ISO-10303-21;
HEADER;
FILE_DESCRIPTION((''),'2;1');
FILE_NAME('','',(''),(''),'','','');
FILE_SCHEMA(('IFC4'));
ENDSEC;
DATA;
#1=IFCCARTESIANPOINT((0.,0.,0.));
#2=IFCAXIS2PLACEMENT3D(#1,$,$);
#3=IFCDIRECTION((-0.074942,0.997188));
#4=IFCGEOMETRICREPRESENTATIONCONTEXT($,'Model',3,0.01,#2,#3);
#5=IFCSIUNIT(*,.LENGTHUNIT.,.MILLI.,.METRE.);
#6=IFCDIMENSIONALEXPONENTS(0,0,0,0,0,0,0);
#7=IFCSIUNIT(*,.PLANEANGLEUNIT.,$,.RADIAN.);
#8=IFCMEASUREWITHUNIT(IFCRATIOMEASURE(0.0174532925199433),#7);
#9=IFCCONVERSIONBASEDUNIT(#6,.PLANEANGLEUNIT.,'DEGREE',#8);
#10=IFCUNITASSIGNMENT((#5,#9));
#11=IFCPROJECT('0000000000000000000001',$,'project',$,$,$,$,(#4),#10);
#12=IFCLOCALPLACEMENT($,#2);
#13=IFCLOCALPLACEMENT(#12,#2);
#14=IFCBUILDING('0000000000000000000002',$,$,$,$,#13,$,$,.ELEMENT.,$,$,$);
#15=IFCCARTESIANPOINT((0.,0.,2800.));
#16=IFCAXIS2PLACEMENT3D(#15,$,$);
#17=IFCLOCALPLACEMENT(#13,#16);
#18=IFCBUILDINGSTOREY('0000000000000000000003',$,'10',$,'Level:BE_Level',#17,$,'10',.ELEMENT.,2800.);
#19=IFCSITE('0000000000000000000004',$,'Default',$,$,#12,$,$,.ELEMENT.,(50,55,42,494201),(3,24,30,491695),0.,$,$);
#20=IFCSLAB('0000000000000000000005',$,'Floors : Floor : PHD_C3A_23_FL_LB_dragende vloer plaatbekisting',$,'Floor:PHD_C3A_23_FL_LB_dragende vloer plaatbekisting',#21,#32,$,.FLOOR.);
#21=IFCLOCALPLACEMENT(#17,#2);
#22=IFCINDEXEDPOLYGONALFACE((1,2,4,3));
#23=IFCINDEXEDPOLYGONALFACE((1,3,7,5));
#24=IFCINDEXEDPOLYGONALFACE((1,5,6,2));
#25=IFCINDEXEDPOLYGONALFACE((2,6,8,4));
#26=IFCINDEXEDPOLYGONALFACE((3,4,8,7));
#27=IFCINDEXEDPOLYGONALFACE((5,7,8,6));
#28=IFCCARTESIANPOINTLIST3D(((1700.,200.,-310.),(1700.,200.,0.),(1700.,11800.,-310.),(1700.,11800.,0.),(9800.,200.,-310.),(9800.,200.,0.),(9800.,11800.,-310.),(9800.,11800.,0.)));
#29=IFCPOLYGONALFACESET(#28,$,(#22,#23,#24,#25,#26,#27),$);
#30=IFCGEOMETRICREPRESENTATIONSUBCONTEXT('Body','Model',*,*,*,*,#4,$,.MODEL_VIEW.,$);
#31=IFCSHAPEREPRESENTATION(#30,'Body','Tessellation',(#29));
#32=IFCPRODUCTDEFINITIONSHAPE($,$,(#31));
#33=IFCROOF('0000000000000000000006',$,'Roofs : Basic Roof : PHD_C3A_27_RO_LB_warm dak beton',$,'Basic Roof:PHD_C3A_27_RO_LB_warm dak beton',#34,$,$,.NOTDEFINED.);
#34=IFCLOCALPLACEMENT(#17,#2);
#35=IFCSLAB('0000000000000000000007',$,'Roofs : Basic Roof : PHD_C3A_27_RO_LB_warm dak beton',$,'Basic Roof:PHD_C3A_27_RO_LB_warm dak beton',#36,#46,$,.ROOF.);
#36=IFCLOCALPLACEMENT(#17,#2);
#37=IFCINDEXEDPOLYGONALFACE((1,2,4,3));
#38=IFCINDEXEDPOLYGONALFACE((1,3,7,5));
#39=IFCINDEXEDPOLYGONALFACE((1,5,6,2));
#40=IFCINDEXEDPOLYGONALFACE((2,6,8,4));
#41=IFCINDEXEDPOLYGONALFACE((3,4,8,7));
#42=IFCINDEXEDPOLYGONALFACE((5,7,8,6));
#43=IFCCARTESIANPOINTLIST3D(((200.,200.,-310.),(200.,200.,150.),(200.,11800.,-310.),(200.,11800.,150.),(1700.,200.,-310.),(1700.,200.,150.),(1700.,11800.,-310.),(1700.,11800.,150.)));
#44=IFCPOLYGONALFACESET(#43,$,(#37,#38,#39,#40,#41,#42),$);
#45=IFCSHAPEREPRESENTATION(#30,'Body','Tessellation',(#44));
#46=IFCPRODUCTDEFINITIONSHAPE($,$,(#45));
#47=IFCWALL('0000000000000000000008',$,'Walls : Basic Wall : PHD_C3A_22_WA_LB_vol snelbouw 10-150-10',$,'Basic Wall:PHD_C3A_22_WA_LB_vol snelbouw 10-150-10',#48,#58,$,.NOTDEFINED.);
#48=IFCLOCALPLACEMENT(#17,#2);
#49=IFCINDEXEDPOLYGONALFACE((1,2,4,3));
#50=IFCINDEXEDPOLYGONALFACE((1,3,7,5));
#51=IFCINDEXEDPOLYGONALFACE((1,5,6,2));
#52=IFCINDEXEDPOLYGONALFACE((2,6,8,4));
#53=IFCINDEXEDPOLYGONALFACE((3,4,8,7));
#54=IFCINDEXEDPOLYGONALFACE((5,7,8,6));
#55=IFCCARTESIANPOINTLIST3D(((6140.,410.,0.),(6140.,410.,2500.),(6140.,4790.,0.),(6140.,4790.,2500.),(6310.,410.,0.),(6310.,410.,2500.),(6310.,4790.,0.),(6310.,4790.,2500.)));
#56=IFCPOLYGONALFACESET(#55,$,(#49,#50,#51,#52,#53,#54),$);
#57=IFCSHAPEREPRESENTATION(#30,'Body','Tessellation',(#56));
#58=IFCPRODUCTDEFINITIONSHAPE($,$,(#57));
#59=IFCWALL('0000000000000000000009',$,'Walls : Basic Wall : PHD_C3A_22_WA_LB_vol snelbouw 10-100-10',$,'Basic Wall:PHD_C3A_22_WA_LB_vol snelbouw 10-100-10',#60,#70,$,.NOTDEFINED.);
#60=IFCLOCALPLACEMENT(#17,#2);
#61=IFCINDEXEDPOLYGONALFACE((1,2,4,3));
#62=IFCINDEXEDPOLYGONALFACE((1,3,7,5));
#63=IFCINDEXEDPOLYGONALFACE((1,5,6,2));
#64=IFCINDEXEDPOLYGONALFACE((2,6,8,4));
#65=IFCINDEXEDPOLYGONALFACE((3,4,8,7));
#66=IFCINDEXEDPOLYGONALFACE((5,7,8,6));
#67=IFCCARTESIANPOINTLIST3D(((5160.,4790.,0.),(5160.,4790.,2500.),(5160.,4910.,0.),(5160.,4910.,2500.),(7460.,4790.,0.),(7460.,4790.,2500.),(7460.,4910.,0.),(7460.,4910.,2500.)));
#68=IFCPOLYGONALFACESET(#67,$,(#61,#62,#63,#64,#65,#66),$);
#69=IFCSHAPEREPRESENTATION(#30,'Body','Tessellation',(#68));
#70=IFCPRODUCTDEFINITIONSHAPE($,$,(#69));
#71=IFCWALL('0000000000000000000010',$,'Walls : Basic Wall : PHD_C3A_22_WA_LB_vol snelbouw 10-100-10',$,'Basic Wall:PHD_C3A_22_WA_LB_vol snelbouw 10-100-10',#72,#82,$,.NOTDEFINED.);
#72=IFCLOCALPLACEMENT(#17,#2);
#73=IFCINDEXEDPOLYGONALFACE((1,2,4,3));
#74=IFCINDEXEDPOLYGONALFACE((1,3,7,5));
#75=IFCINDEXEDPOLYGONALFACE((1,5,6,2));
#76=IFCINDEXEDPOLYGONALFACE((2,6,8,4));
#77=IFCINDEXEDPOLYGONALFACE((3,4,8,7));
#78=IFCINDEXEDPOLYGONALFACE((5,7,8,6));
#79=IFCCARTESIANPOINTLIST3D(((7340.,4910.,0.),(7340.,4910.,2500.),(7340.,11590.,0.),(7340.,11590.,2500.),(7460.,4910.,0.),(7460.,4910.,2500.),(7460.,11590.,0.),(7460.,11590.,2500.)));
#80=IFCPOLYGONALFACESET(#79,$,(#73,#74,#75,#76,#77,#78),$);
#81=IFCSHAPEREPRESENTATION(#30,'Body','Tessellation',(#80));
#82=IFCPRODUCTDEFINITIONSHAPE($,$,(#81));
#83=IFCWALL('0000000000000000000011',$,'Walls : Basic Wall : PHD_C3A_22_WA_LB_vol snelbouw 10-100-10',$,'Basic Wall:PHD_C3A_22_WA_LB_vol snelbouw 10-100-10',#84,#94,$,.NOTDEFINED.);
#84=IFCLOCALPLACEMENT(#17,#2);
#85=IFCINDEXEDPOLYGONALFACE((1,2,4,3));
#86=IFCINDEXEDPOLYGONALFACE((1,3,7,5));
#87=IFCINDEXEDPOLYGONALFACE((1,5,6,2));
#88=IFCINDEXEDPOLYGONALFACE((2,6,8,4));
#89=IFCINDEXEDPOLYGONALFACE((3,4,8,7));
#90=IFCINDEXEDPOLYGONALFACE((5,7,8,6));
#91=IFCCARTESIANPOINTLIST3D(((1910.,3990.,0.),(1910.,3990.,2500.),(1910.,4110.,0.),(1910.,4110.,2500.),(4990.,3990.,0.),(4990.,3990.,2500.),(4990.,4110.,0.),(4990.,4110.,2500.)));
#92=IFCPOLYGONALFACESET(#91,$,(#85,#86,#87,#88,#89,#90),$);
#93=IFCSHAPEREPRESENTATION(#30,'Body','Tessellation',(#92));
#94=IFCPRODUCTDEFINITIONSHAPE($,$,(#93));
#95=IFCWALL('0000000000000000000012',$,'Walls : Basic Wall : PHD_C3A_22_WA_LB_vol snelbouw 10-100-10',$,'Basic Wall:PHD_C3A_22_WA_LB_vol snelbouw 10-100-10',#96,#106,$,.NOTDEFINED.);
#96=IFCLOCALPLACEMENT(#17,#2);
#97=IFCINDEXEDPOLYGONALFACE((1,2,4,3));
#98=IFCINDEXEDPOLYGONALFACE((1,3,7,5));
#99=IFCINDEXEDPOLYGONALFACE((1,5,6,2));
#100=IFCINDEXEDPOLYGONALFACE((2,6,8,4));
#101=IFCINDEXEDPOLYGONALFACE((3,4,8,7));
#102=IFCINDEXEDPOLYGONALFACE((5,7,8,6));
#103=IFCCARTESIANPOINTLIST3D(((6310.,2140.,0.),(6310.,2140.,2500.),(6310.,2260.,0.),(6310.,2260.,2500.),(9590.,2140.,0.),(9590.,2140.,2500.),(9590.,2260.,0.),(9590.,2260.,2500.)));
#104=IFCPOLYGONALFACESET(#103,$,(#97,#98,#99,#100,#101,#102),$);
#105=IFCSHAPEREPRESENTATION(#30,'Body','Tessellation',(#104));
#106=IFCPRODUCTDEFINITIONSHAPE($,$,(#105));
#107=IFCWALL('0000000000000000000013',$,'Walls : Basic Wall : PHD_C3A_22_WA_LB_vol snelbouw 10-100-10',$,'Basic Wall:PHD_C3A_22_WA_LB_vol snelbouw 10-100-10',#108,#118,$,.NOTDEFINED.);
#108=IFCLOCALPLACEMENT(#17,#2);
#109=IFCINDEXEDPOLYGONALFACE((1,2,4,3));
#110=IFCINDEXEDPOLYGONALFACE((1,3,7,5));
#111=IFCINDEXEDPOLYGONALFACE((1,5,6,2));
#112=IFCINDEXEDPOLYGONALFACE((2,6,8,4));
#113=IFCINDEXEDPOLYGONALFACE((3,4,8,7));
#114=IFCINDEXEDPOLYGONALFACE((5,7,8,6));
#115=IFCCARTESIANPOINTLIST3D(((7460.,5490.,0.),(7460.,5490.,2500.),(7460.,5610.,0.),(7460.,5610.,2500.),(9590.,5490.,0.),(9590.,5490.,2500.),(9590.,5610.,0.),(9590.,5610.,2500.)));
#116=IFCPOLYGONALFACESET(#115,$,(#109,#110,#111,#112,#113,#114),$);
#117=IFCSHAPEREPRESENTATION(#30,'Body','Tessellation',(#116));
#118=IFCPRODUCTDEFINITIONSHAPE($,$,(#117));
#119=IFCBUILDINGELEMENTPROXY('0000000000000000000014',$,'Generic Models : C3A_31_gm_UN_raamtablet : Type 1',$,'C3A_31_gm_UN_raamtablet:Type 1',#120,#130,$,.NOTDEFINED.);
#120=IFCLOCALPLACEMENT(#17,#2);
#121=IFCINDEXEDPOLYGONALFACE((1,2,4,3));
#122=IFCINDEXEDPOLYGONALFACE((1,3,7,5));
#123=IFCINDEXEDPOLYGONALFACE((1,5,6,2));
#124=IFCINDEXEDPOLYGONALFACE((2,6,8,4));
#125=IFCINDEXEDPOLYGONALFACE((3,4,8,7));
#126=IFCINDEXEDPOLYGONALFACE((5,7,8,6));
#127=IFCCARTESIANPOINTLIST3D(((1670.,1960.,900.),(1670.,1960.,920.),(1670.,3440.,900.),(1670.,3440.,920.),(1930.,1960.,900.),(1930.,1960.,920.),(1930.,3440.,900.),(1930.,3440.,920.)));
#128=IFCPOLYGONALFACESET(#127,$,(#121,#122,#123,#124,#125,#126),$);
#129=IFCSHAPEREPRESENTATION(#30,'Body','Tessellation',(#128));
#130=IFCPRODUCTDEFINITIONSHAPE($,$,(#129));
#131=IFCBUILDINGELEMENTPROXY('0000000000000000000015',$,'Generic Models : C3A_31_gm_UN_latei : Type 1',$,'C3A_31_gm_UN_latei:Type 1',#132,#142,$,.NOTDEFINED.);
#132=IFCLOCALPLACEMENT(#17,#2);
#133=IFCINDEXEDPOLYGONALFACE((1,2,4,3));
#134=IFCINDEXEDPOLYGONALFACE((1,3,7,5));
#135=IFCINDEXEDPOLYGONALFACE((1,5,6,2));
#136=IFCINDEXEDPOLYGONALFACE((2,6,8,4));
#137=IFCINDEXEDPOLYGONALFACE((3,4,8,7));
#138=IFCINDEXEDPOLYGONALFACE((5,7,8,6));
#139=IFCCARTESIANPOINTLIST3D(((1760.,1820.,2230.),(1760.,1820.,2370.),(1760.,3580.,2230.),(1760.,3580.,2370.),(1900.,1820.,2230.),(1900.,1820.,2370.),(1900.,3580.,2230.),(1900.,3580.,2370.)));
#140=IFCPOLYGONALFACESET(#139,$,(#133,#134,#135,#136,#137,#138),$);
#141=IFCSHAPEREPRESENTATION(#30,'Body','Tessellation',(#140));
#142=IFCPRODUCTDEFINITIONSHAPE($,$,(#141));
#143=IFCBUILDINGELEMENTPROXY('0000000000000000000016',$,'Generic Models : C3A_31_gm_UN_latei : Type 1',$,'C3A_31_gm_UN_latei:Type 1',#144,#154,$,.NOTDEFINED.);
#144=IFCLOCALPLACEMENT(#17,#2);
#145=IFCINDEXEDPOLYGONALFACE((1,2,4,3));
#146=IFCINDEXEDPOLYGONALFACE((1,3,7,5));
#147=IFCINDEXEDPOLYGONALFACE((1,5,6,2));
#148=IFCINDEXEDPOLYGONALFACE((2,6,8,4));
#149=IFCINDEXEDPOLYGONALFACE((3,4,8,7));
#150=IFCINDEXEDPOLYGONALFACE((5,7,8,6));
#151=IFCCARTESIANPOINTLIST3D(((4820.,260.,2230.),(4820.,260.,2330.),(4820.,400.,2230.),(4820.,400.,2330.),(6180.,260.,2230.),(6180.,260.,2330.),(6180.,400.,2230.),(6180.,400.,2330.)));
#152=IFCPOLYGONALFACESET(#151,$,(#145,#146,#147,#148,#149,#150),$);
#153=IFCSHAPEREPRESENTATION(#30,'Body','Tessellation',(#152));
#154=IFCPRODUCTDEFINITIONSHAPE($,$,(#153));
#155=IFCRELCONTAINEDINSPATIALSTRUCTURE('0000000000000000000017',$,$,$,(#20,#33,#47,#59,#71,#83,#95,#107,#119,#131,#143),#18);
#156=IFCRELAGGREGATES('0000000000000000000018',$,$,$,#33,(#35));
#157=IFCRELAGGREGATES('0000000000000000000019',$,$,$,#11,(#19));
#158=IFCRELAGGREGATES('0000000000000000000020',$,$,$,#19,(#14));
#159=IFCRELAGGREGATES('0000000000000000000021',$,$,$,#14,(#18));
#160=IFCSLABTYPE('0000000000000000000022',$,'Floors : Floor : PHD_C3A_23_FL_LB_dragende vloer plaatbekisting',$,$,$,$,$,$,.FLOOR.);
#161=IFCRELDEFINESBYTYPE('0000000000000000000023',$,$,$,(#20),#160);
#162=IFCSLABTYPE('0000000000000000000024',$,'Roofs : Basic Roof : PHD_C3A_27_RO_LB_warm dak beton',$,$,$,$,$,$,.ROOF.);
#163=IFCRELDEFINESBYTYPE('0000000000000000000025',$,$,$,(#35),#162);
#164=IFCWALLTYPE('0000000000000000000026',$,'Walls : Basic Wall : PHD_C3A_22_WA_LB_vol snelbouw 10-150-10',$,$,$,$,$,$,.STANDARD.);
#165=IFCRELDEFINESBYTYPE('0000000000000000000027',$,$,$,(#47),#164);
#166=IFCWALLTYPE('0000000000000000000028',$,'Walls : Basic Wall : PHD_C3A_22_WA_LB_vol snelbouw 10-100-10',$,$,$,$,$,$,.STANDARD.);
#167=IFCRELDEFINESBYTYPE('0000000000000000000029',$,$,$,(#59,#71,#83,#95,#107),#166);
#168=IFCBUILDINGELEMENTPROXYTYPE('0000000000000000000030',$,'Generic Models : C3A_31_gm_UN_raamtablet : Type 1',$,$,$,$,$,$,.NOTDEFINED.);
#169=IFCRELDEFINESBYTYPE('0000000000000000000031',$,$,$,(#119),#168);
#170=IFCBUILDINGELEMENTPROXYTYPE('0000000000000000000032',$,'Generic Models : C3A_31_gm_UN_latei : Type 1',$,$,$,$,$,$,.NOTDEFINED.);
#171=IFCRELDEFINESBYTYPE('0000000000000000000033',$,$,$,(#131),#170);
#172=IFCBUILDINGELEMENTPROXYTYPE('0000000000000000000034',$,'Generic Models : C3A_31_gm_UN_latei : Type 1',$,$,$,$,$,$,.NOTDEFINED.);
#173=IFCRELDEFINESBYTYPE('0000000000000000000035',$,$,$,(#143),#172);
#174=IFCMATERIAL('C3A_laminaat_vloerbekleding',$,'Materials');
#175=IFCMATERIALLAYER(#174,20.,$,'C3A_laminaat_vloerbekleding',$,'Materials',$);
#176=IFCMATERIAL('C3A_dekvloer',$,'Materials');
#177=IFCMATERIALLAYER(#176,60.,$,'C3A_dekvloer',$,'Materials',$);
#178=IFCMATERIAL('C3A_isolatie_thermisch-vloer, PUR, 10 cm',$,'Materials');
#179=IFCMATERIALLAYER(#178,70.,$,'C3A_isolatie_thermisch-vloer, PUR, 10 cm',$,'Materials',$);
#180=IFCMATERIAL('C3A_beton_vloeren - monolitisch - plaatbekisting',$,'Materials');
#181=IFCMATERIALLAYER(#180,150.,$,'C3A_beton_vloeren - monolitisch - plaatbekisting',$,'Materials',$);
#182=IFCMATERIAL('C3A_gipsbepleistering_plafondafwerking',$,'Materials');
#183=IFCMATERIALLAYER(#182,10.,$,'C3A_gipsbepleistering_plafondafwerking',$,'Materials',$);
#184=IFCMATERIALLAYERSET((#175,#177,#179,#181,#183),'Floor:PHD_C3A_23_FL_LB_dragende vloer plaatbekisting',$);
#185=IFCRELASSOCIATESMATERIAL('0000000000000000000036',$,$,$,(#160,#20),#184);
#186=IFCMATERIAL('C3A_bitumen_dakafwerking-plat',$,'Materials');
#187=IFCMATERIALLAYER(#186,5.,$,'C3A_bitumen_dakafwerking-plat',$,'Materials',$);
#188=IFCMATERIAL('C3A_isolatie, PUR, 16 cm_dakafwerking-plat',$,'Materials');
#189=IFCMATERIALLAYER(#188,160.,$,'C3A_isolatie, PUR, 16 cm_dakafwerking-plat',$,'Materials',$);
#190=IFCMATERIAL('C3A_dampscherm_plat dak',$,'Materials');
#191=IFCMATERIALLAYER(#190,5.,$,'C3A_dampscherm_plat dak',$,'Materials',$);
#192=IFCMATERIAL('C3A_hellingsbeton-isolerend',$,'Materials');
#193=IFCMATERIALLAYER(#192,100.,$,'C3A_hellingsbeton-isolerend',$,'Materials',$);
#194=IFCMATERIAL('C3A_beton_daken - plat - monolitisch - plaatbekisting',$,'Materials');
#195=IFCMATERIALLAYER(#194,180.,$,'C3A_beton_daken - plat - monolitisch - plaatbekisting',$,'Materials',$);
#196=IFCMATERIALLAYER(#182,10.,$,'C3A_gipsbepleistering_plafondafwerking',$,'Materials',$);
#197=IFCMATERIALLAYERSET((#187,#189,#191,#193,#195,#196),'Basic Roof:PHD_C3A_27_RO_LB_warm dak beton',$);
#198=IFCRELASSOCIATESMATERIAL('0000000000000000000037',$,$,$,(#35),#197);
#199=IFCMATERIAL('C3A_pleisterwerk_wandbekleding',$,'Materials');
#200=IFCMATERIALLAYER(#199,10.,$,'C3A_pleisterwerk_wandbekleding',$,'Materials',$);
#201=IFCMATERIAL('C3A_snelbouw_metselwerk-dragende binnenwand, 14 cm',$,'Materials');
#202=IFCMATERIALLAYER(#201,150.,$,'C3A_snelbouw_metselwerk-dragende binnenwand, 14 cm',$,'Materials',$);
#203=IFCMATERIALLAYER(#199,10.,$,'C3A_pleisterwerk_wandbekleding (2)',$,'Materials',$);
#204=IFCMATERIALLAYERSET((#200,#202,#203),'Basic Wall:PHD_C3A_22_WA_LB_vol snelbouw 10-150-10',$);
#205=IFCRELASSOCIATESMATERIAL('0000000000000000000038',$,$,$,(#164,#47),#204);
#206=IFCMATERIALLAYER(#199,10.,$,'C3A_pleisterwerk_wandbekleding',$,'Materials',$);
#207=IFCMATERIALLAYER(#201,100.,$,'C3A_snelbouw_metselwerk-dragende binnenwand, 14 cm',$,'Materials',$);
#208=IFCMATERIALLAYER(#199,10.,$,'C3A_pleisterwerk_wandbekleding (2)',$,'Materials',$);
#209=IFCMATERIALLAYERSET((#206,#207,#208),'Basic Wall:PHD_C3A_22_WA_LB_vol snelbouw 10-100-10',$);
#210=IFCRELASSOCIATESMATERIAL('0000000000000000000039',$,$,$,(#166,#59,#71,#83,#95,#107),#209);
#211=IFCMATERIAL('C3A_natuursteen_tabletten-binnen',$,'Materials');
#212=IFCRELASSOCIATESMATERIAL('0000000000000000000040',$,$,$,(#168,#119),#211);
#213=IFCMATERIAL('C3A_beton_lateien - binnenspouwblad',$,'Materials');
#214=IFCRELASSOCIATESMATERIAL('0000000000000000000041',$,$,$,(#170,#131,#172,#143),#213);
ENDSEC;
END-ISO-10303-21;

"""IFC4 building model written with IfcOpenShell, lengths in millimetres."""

from ifc_helpers import new_model, entity, si_unit, converted_unit, direction, frame, frame_2d, origin, origin_2d_with_axis, place, context, subcontext, project, spatial, rectangle, extrude, source, transform, mapped, material, layer, layer_set, layer_usage, type_object, type_shapes, element, aggregate, save


model = new_model("IFC4")

# Units and contexts
model_context = context("Model", 3, precision=0.01, world=origin(), true_north=direction((-0.074942, 0.997188)))
body_context = subcontext(model_context, "Body", "Model", "MODEL_VIEW")
ifc_project = project(units=[si_unit("LENGTHUNIT", "METRE", prefix="MILLI"), converted_unit("PLANEANGLEUNIT", "DEGREE", entity("IfcRatioMeasure", 0.0174532925199433), si_unit("PLANEANGLEUNIT", "RADIAN"), dimensions=[0, 0, 0, 0, 0, 0, 0])], contexts=[model_context])

# Site, building, storey
site_placement = place(None, origin())
site = spatial("IfcSite", under=ifc_project, at=site_placement, Name="Default", CompositionType="ELEMENT", RefLatitude=(50, 55, 42, 494201), RefLongitude=(3, 24, 30, 491695), RefElevation=0.0)
building_placement = place(site_placement, origin())
building = spatial("IfcBuilding", under=site, at=building_placement, CompositionType="ELEMENT")
storey_placement = place(building_placement, frame((0.0, 0.0, 2800.0)))
storey = spatial("IfcBuildingStorey", under=building, at=storey_placement, Name="10", ObjectType="Level:BE_Level", LongName="10", CompositionType="ELEMENT", Elevation=2800.0)

# Slab
ifc_material_1 = material(Name="C3A_laminaat_vloerbekleding", Category="Materials")
ifc_layer_1 = layer(ifc_material_1, 20.0, Name="C3A_laminaat_vloerbekleding", Category="Materials")
ifc_material_2 = material(Name="C3A_dekvloer", Category="Materials")
ifc_layer_2 = layer(ifc_material_2, 60.0, Name="C3A_dekvloer", Category="Materials")
ifc_material_3 = material(Name="C3A_isolatie_thermisch-vloer, PUR, 10 cm", Category="Materials")
ifc_layer_3 = layer(ifc_material_3, 70.0, Name="C3A_isolatie_thermisch-vloer, PUR, 10 cm", Category="Materials")
ifc_material_4 = material(Name="C3A_beton_vloeren - monolitisch - plaatbekisting", Category="Materials")
ifc_layer_4 = layer(ifc_material_4, 150.0, Name="C3A_beton_vloeren - monolitisch - plaatbekisting", Category="Materials")
ifc_material_5 = material(Name="C3A_gipsbepleistering_plafondafwerking", Category="Materials")
ifc_layer_5 = layer(ifc_material_5, 10.0, Name="C3A_gipsbepleistering_plafondafwerking", Category="Materials")
ifc_layer_set_1 = layer_set([ifc_layer_1, ifc_layer_2, ifc_layer_3, ifc_layer_4, ifc_layer_5], Name="Floor:PHD_C3A_23_FL_LB_dragende vloer plaatbekisting")
ifc_layer_usage_1 = layer_usage(ifc_layer_set_1, "AXIS3", "POSITIVE", 0.0)
slab_type_1 = type_object("IfcSlabType", Name="Floors : Floor : PHD_C3A_23_FL_LB_dragende vloer plaatbekisting", PredefinedType="FLOOR", material=ifc_layer_set_1)
slab_1_placement = place(storey_placement, origin())
element("IfcSlab", 1, at=slab_1_placement, inside=storey, type_object=slab_type_1, material=ifc_layer_usage_1, Name="Floors : Floor : PHD_C3A_23_FL_LB_dragende vloer plaatbekisting", ObjectType="Floor:PHD_C3A_23_FL_LB_dragende vloer plaatbekisting", PredefinedType="FLOOR", context=body_context, shape_type="SweptSolid", body=[
    extrude(rectangle(XDim=11600.0, YDim=8100.0, at=frame_2d((0.0, 0.0), x_axis=(1.0, 0.0))), frame((5750.0, 6000.0, 0.0), z_axis=(0.0, 0.0, -1.0), x_axis=(0.0, 1.0, 0.0)), (0.0, 0.0, 1.0), 310.0),
])

# Roof, slab
roof_placement = place(storey_placement, frame((200.0, 200.0, -310.0)))
roof = element("IfcRoof", 2, at=roof_placement, inside=storey, Name="Roofs : Basic Roof : PHD_C3A_27_RO_LB_warm dak beton", ObjectType="Basic Roof:PHD_C3A_27_RO_LB_warm dak beton", PredefinedType="NOTDEFINED")
ifc_material_6 = material(Name="C3A_bitumen_dakafwerking-plat", Category="Materials")
ifc_layer_6 = layer(ifc_material_6, 5.0, Name="C3A_bitumen_dakafwerking-plat", Category="Materials")
ifc_material_7 = material(Name="C3A_isolatie, PUR, 16 cm_dakafwerking-plat", Category="Materials")
ifc_layer_7 = layer(ifc_material_7, 160.0, Name="C3A_isolatie, PUR, 16 cm_dakafwerking-plat", Category="Materials")
ifc_material_8 = material(Name="C3A_dampscherm_plat dak", Category="Materials")
ifc_layer_8 = layer(ifc_material_8, 5.0, Name="C3A_dampscherm_plat dak", Category="Materials")
ifc_material_9 = material(Name="C3A_hellingsbeton-isolerend", Category="Materials")
ifc_layer_9 = layer(ifc_material_9, 100.0, Name="C3A_hellingsbeton-isolerend", Category="Materials")
ifc_material_10 = material(Name="C3A_beton_daken - plat - monolitisch - plaatbekisting", Category="Materials")
ifc_layer_10 = layer(ifc_material_10, 180.0, Name="C3A_beton_daken - plat - monolitisch - plaatbekisting", Category="Materials")
ifc_layer_11 = layer(ifc_material_5, 10.0, Name="C3A_gipsbepleistering_plafondafwerking", Category="Materials")
ifc_layer_set_2 = layer_set([ifc_layer_6, ifc_layer_7, ifc_layer_8, ifc_layer_9, ifc_layer_10, ifc_layer_11], Name="Basic Roof:PHD_C3A_27_RO_LB_warm dak beton")
slab_type_2 = type_object("IfcSlabType", Name="Roofs : Basic Roof : PHD_C3A_27_RO_LB_warm dak beton", PredefinedType="ROOF")
slab_2_placement = place(roof_placement, origin())
slab_2 = element("IfcSlab", 3, at=slab_2_placement, type_object=slab_type_2, material=ifc_layer_set_2, Name="Roofs : Basic Roof : PHD_C3A_27_RO_LB_warm dak beton", ObjectType="Basic Roof:PHD_C3A_27_RO_LB_warm dak beton", PredefinedType="ROOF", context=body_context, shape_type="SweptSolid", body=[
    extrude(rectangle(XDim=1500.0, YDim=11600.0, at=frame_2d((0.0, 0.0), x_axis=(1.0, 0.0))), frame((750.0, 5800.0, 0.0)), (0.0, 0.0, 1.0), 460.0),
])
aggregate(roof, [slab_2])

# Walls
ifc_material_11 = material(Name="C3A_pleisterwerk_wandbekleding", Category="Materials")
ifc_layer_12 = layer(ifc_material_11, 10.0, Name="C3A_pleisterwerk_wandbekleding", Category="Materials")
ifc_material_12 = material(Name="C3A_snelbouw_metselwerk-dragende binnenwand, 14 cm", Category="Materials")
ifc_layer_13 = layer(ifc_material_12, 150.0, Name="C3A_snelbouw_metselwerk-dragende binnenwand, 14 cm", Category="Materials")
ifc_layer_14 = layer(ifc_material_11, 10.0, Name="C3A_pleisterwerk_wandbekleding (2)", Category="Materials")
ifc_layer_set_3 = layer_set([ifc_layer_12, ifc_layer_13, ifc_layer_14], Name="Basic Wall:PHD_C3A_22_WA_LB_vol snelbouw 10-150-10")
ifc_layer_usage_2 = layer_usage(ifc_layer_set_3, "AXIS2", "NEGATIVE", 85.0)
wall_type_1 = type_object("IfcWallType", Name="Walls : Basic Wall : PHD_C3A_22_WA_LB_vol snelbouw 10-150-10", PredefinedType="STANDARD", material=ifc_layer_set_3)
wall_1_placement = place(storey_placement, frame((6225.0, 4790.0, 0.0), z_axis=(0.0, 0.0, 1.0), x_axis=(0.0, -1.0, 0.0)))
element("IfcWall", 4, at=wall_1_placement, inside=storey, type_object=wall_type_1, material=ifc_layer_usage_2, Name="Walls : Basic Wall : PHD_C3A_22_WA_LB_vol snelbouw 10-150-10", ObjectType="Basic Wall:PHD_C3A_22_WA_LB_vol snelbouw 10-150-10", PredefinedType="NOTDEFINED", context=body_context, shape_type="SweptSolid", body=[
    extrude(rectangle(XDim=4380.0, YDim=170.0, at=frame_2d((2190.0, 0.0), x_axis=(-1.0, 0.0))), origin(), (0.0, 0.0, 1.0), 2500.0),
])
ifc_layer_15 = layer(ifc_material_11, 10.0, Name="C3A_pleisterwerk_wandbekleding", Category="Materials")
ifc_layer_16 = layer(ifc_material_12, 100.0, Name="C3A_snelbouw_metselwerk-dragende binnenwand, 14 cm", Category="Materials")
ifc_layer_17 = layer(ifc_material_11, 10.0, Name="C3A_pleisterwerk_wandbekleding (2)", Category="Materials")
ifc_layer_set_4 = layer_set([ifc_layer_15, ifc_layer_16, ifc_layer_17], Name="Basic Wall:PHD_C3A_22_WA_LB_vol snelbouw 10-100-10")
ifc_layer_usage_3 = layer_usage(ifc_layer_set_4, "AXIS2", "NEGATIVE", 60.0)
wall_type_2 = type_object("IfcWallType", Name="Walls : Basic Wall : PHD_C3A_22_WA_LB_vol snelbouw 10-100-10", PredefinedType="STANDARD", material=ifc_layer_set_4)
wall_2_placement = place(storey_placement, frame((5160.0, 4850.0, 0.0)))
element("IfcWall", 5, at=wall_2_placement, inside=storey, type_object=wall_type_2, material=ifc_layer_usage_3, Name="Walls : Basic Wall : PHD_C3A_22_WA_LB_vol snelbouw 10-100-10", ObjectType="Basic Wall:PHD_C3A_22_WA_LB_vol snelbouw 10-100-10", PredefinedType="NOTDEFINED", context=body_context, shape_type="SweptSolid", body=[
    extrude(rectangle(XDim=2300.0, YDim=120.0, at=frame_2d((1150.0, 0.0), x_axis=(-1.0, 0.0))), origin(), (0.0, 0.0, 1.0), 2500.0),
])
ifc_layer_usage_4 = layer_usage(ifc_layer_set_4, "AXIS2", "NEGATIVE", 60.0)
wall_3_placement = place(storey_placement, frame((7400.0, 4910.0, 0.0), z_axis=(0.0, 0.0, 1.0), x_axis=(0.0, 1.0, 0.0)))
element("IfcWall", 6, at=wall_3_placement, inside=storey, type_object=wall_type_2, material=ifc_layer_usage_4, Name="Walls : Basic Wall : PHD_C3A_22_WA_LB_vol snelbouw 10-100-10", ObjectType="Basic Wall:PHD_C3A_22_WA_LB_vol snelbouw 10-100-10", PredefinedType="NOTDEFINED", context=body_context, shape_type="SweptSolid", body=[
    extrude(rectangle(XDim=6680.0, YDim=120.0, at=frame_2d((3340.0, 0.0), x_axis=(-1.0, 0.0))), origin(), (0.0, 0.0, 1.0), 2500.0),
])
ifc_layer_usage_5 = layer_usage(ifc_layer_set_4, "AXIS2", "NEGATIVE", 60.0)
wall_4_placement = place(storey_placement, frame((4990.0, 4050.0, 0.0), z_axis=(0.0, 0.0, 1.0), x_axis=(-1.0, 0.0, 0.0)))
element("IfcWall", 7, at=wall_4_placement, inside=storey, type_object=wall_type_2, material=ifc_layer_usage_5, Name="Walls : Basic Wall : PHD_C3A_22_WA_LB_vol snelbouw 10-100-10", ObjectType="Basic Wall:PHD_C3A_22_WA_LB_vol snelbouw 10-100-10", PredefinedType="NOTDEFINED", context=body_context, shape_type="SweptSolid", body=[
    extrude(rectangle(XDim=3080.0, YDim=120.0, at=frame_2d((1540.0, 0.0), x_axis=(-1.0, 0.0))), origin(), (0.0, 0.0, 1.0), 2500.0),
])
ifc_layer_usage_6 = layer_usage(ifc_layer_set_4, "AXIS2", "NEGATIVE", 60.0)
wall_5_placement = place(storey_placement, frame((6310.0, 2200.0, 0.0)))
element("IfcWall", 8, at=wall_5_placement, inside=storey, type_object=wall_type_2, material=ifc_layer_usage_6, Name="Walls : Basic Wall : PHD_C3A_22_WA_LB_vol snelbouw 10-100-10", ObjectType="Basic Wall:PHD_C3A_22_WA_LB_vol snelbouw 10-100-10", PredefinedType="NOTDEFINED", context=body_context, shape_type="SweptSolid", body=[
    extrude(rectangle(XDim=3280.0, YDim=120.0, at=frame_2d((1640.0, 0.0), x_axis=(-1.0, 0.0))), origin(), (0.0, 0.0, 1.0), 2500.0),
])
ifc_layer_usage_7 = layer_usage(ifc_layer_set_4, "AXIS2", "NEGATIVE", 60.0)
wall_6_placement = place(storey_placement, frame((7460.0, 5550.0, 0.0)))
element("IfcWall", 9, at=wall_6_placement, inside=storey, type_object=wall_type_2, material=ifc_layer_usage_7, Name="Walls : Basic Wall : PHD_C3A_22_WA_LB_vol snelbouw 10-100-10", ObjectType="Basic Wall:PHD_C3A_22_WA_LB_vol snelbouw 10-100-10", PredefinedType="NOTDEFINED", context=body_context, shape_type="SweptSolid", body=[
    extrude(rectangle(XDim=2130.0, YDim=120.0, at=frame_2d((1065.0, 0.0), x_axis=(-1.0, 0.0))), origin(), (0.0, 0.0, 1.0), 2500.0),
])

# Building element proxies
ifc_material_13 = material(Name="C3A_natuursteen_tabletten-binnen", Category="Materials")
building_element_proxy_type_1 = type_object("IfcBuildingElementProxyType", Name="Generic Models : C3A_31_gm_UN_raamtablet : Type 1", PredefinedType="NOTDEFINED", material=ifc_material_13)
shared_shape_1 = source(origin(), body_context, "Body", "SweptSolid", [
    extrude(rectangle(XDim=1480.0, YDim=260.0, at=origin_2d_with_axis()), frame((0.0, 130.0, 0.0), z_axis=(0.0, 0.0, 1.0), x_axis=(-1.0, 0.0, 0.0)), (0.0, 0.0, 1.0), 20.0),
])
type_shapes(building_element_proxy_type_1, [shared_shape_1])
proxy_1_placement = place(storey_placement, frame((1930.0, 2700.0, 900.0), z_axis=(0.0, 0.0, 1.0), x_axis=(0.0, 1.0, 0.0)))
element("IfcBuildingElementProxy", 10, at=proxy_1_placement, inside=storey, type_object=building_element_proxy_type_1, material=ifc_material_13, Name="Generic Models : C3A_31_gm_UN_raamtablet : Type 1", ObjectType="C3A_31_gm_UN_raamtablet:Type 1", PredefinedType="NOTDEFINED", context=body_context, shape_type="MappedRepresentation", body=[
    mapped(shared_shape_1, transform((0.0, 0.0, 0.0), scale=1.0)),
])
ifc_material_14 = material(Name="C3A_beton_lateien - binnenspouwblad", Category="Materials")
building_element_proxy_type_2 = type_object("IfcBuildingElementProxyType", Name="Generic Models : C3A_31_gm_UN_latei : Type 1", PredefinedType="NOTDEFINED", material=ifc_material_14)
shared_shape_2 = source(origin(), body_context, "Body", "SweptSolid", [
    extrude(rectangle(XDim=1760.0, YDim=140.0, at=origin_2d_with_axis()), frame((0.0, 70.0, 0.0), z_axis=(0.0, 0.0, 1.0), x_axis=(-1.0, 0.0, 0.0)), (0.0, 0.0, 1.0), 140.0),
])
type_shapes(building_element_proxy_type_2, [shared_shape_2])
proxy_2_placement = place(storey_placement, frame((1900.0, 2700.0, 2230.0), z_axis=(0.0, 0.0, 1.0), x_axis=(0.0, 1.0, 0.0)))
element("IfcBuildingElementProxy", 11, at=proxy_2_placement, inside=storey, type_object=building_element_proxy_type_2, material=ifc_material_14, Name="Generic Models : C3A_31_gm_UN_latei : Type 1", ObjectType="C3A_31_gm_UN_latei:Type 1", PredefinedType="NOTDEFINED", context=body_context, shape_type="MappedRepresentation", body=[
    mapped(shared_shape_2, transform((0.0, 0.0, 0.0), scale=1.0)),
])
building_element_proxy_type_3 = type_object("IfcBuildingElementProxyType", Name="Generic Models : C3A_31_gm_UN_latei : Type 1", PredefinedType="NOTDEFINED", material=ifc_material_14)
shared_shape_3 = source(origin(), body_context, "Body", "SweptSolid", [
    extrude(rectangle(XDim=1360.0, YDim=140.0, at=origin_2d_with_axis()), frame((0.0, 70.0, 0.0), z_axis=(0.0, 0.0, 1.0), x_axis=(-1.0, 0.0, 0.0)), (0.0, 0.0, 1.0), 100.0),
])
type_shapes(building_element_proxy_type_3, [shared_shape_3])
for number, where, z_axis, x_axis, name in (
    (12, (5500.0, 400.0, 2230.0), (0.0, 0.0, 1.0), (-1.0, 0.0, 0.0), "Generic Models : C3A_31_gm_UN_latei : Type 1"),
):
    element("IfcBuildingElementProxy", number, at=place(storey_placement, frame(where, z_axis=z_axis, x_axis=x_axis)), inside=storey, type_object=building_element_proxy_type_3, material=ifc_material_14, Name=name, ObjectType="C3A_31_gm_UN_latei:Type 1", PredefinedType="NOTDEFINED", context=body_context, shape_type="MappedRepresentation", body=[
        mapped(shared_shape_3, transform((0.0, 0.0, 0.0), scale=1.0)),
    ])

save(model, "model.ifc")
